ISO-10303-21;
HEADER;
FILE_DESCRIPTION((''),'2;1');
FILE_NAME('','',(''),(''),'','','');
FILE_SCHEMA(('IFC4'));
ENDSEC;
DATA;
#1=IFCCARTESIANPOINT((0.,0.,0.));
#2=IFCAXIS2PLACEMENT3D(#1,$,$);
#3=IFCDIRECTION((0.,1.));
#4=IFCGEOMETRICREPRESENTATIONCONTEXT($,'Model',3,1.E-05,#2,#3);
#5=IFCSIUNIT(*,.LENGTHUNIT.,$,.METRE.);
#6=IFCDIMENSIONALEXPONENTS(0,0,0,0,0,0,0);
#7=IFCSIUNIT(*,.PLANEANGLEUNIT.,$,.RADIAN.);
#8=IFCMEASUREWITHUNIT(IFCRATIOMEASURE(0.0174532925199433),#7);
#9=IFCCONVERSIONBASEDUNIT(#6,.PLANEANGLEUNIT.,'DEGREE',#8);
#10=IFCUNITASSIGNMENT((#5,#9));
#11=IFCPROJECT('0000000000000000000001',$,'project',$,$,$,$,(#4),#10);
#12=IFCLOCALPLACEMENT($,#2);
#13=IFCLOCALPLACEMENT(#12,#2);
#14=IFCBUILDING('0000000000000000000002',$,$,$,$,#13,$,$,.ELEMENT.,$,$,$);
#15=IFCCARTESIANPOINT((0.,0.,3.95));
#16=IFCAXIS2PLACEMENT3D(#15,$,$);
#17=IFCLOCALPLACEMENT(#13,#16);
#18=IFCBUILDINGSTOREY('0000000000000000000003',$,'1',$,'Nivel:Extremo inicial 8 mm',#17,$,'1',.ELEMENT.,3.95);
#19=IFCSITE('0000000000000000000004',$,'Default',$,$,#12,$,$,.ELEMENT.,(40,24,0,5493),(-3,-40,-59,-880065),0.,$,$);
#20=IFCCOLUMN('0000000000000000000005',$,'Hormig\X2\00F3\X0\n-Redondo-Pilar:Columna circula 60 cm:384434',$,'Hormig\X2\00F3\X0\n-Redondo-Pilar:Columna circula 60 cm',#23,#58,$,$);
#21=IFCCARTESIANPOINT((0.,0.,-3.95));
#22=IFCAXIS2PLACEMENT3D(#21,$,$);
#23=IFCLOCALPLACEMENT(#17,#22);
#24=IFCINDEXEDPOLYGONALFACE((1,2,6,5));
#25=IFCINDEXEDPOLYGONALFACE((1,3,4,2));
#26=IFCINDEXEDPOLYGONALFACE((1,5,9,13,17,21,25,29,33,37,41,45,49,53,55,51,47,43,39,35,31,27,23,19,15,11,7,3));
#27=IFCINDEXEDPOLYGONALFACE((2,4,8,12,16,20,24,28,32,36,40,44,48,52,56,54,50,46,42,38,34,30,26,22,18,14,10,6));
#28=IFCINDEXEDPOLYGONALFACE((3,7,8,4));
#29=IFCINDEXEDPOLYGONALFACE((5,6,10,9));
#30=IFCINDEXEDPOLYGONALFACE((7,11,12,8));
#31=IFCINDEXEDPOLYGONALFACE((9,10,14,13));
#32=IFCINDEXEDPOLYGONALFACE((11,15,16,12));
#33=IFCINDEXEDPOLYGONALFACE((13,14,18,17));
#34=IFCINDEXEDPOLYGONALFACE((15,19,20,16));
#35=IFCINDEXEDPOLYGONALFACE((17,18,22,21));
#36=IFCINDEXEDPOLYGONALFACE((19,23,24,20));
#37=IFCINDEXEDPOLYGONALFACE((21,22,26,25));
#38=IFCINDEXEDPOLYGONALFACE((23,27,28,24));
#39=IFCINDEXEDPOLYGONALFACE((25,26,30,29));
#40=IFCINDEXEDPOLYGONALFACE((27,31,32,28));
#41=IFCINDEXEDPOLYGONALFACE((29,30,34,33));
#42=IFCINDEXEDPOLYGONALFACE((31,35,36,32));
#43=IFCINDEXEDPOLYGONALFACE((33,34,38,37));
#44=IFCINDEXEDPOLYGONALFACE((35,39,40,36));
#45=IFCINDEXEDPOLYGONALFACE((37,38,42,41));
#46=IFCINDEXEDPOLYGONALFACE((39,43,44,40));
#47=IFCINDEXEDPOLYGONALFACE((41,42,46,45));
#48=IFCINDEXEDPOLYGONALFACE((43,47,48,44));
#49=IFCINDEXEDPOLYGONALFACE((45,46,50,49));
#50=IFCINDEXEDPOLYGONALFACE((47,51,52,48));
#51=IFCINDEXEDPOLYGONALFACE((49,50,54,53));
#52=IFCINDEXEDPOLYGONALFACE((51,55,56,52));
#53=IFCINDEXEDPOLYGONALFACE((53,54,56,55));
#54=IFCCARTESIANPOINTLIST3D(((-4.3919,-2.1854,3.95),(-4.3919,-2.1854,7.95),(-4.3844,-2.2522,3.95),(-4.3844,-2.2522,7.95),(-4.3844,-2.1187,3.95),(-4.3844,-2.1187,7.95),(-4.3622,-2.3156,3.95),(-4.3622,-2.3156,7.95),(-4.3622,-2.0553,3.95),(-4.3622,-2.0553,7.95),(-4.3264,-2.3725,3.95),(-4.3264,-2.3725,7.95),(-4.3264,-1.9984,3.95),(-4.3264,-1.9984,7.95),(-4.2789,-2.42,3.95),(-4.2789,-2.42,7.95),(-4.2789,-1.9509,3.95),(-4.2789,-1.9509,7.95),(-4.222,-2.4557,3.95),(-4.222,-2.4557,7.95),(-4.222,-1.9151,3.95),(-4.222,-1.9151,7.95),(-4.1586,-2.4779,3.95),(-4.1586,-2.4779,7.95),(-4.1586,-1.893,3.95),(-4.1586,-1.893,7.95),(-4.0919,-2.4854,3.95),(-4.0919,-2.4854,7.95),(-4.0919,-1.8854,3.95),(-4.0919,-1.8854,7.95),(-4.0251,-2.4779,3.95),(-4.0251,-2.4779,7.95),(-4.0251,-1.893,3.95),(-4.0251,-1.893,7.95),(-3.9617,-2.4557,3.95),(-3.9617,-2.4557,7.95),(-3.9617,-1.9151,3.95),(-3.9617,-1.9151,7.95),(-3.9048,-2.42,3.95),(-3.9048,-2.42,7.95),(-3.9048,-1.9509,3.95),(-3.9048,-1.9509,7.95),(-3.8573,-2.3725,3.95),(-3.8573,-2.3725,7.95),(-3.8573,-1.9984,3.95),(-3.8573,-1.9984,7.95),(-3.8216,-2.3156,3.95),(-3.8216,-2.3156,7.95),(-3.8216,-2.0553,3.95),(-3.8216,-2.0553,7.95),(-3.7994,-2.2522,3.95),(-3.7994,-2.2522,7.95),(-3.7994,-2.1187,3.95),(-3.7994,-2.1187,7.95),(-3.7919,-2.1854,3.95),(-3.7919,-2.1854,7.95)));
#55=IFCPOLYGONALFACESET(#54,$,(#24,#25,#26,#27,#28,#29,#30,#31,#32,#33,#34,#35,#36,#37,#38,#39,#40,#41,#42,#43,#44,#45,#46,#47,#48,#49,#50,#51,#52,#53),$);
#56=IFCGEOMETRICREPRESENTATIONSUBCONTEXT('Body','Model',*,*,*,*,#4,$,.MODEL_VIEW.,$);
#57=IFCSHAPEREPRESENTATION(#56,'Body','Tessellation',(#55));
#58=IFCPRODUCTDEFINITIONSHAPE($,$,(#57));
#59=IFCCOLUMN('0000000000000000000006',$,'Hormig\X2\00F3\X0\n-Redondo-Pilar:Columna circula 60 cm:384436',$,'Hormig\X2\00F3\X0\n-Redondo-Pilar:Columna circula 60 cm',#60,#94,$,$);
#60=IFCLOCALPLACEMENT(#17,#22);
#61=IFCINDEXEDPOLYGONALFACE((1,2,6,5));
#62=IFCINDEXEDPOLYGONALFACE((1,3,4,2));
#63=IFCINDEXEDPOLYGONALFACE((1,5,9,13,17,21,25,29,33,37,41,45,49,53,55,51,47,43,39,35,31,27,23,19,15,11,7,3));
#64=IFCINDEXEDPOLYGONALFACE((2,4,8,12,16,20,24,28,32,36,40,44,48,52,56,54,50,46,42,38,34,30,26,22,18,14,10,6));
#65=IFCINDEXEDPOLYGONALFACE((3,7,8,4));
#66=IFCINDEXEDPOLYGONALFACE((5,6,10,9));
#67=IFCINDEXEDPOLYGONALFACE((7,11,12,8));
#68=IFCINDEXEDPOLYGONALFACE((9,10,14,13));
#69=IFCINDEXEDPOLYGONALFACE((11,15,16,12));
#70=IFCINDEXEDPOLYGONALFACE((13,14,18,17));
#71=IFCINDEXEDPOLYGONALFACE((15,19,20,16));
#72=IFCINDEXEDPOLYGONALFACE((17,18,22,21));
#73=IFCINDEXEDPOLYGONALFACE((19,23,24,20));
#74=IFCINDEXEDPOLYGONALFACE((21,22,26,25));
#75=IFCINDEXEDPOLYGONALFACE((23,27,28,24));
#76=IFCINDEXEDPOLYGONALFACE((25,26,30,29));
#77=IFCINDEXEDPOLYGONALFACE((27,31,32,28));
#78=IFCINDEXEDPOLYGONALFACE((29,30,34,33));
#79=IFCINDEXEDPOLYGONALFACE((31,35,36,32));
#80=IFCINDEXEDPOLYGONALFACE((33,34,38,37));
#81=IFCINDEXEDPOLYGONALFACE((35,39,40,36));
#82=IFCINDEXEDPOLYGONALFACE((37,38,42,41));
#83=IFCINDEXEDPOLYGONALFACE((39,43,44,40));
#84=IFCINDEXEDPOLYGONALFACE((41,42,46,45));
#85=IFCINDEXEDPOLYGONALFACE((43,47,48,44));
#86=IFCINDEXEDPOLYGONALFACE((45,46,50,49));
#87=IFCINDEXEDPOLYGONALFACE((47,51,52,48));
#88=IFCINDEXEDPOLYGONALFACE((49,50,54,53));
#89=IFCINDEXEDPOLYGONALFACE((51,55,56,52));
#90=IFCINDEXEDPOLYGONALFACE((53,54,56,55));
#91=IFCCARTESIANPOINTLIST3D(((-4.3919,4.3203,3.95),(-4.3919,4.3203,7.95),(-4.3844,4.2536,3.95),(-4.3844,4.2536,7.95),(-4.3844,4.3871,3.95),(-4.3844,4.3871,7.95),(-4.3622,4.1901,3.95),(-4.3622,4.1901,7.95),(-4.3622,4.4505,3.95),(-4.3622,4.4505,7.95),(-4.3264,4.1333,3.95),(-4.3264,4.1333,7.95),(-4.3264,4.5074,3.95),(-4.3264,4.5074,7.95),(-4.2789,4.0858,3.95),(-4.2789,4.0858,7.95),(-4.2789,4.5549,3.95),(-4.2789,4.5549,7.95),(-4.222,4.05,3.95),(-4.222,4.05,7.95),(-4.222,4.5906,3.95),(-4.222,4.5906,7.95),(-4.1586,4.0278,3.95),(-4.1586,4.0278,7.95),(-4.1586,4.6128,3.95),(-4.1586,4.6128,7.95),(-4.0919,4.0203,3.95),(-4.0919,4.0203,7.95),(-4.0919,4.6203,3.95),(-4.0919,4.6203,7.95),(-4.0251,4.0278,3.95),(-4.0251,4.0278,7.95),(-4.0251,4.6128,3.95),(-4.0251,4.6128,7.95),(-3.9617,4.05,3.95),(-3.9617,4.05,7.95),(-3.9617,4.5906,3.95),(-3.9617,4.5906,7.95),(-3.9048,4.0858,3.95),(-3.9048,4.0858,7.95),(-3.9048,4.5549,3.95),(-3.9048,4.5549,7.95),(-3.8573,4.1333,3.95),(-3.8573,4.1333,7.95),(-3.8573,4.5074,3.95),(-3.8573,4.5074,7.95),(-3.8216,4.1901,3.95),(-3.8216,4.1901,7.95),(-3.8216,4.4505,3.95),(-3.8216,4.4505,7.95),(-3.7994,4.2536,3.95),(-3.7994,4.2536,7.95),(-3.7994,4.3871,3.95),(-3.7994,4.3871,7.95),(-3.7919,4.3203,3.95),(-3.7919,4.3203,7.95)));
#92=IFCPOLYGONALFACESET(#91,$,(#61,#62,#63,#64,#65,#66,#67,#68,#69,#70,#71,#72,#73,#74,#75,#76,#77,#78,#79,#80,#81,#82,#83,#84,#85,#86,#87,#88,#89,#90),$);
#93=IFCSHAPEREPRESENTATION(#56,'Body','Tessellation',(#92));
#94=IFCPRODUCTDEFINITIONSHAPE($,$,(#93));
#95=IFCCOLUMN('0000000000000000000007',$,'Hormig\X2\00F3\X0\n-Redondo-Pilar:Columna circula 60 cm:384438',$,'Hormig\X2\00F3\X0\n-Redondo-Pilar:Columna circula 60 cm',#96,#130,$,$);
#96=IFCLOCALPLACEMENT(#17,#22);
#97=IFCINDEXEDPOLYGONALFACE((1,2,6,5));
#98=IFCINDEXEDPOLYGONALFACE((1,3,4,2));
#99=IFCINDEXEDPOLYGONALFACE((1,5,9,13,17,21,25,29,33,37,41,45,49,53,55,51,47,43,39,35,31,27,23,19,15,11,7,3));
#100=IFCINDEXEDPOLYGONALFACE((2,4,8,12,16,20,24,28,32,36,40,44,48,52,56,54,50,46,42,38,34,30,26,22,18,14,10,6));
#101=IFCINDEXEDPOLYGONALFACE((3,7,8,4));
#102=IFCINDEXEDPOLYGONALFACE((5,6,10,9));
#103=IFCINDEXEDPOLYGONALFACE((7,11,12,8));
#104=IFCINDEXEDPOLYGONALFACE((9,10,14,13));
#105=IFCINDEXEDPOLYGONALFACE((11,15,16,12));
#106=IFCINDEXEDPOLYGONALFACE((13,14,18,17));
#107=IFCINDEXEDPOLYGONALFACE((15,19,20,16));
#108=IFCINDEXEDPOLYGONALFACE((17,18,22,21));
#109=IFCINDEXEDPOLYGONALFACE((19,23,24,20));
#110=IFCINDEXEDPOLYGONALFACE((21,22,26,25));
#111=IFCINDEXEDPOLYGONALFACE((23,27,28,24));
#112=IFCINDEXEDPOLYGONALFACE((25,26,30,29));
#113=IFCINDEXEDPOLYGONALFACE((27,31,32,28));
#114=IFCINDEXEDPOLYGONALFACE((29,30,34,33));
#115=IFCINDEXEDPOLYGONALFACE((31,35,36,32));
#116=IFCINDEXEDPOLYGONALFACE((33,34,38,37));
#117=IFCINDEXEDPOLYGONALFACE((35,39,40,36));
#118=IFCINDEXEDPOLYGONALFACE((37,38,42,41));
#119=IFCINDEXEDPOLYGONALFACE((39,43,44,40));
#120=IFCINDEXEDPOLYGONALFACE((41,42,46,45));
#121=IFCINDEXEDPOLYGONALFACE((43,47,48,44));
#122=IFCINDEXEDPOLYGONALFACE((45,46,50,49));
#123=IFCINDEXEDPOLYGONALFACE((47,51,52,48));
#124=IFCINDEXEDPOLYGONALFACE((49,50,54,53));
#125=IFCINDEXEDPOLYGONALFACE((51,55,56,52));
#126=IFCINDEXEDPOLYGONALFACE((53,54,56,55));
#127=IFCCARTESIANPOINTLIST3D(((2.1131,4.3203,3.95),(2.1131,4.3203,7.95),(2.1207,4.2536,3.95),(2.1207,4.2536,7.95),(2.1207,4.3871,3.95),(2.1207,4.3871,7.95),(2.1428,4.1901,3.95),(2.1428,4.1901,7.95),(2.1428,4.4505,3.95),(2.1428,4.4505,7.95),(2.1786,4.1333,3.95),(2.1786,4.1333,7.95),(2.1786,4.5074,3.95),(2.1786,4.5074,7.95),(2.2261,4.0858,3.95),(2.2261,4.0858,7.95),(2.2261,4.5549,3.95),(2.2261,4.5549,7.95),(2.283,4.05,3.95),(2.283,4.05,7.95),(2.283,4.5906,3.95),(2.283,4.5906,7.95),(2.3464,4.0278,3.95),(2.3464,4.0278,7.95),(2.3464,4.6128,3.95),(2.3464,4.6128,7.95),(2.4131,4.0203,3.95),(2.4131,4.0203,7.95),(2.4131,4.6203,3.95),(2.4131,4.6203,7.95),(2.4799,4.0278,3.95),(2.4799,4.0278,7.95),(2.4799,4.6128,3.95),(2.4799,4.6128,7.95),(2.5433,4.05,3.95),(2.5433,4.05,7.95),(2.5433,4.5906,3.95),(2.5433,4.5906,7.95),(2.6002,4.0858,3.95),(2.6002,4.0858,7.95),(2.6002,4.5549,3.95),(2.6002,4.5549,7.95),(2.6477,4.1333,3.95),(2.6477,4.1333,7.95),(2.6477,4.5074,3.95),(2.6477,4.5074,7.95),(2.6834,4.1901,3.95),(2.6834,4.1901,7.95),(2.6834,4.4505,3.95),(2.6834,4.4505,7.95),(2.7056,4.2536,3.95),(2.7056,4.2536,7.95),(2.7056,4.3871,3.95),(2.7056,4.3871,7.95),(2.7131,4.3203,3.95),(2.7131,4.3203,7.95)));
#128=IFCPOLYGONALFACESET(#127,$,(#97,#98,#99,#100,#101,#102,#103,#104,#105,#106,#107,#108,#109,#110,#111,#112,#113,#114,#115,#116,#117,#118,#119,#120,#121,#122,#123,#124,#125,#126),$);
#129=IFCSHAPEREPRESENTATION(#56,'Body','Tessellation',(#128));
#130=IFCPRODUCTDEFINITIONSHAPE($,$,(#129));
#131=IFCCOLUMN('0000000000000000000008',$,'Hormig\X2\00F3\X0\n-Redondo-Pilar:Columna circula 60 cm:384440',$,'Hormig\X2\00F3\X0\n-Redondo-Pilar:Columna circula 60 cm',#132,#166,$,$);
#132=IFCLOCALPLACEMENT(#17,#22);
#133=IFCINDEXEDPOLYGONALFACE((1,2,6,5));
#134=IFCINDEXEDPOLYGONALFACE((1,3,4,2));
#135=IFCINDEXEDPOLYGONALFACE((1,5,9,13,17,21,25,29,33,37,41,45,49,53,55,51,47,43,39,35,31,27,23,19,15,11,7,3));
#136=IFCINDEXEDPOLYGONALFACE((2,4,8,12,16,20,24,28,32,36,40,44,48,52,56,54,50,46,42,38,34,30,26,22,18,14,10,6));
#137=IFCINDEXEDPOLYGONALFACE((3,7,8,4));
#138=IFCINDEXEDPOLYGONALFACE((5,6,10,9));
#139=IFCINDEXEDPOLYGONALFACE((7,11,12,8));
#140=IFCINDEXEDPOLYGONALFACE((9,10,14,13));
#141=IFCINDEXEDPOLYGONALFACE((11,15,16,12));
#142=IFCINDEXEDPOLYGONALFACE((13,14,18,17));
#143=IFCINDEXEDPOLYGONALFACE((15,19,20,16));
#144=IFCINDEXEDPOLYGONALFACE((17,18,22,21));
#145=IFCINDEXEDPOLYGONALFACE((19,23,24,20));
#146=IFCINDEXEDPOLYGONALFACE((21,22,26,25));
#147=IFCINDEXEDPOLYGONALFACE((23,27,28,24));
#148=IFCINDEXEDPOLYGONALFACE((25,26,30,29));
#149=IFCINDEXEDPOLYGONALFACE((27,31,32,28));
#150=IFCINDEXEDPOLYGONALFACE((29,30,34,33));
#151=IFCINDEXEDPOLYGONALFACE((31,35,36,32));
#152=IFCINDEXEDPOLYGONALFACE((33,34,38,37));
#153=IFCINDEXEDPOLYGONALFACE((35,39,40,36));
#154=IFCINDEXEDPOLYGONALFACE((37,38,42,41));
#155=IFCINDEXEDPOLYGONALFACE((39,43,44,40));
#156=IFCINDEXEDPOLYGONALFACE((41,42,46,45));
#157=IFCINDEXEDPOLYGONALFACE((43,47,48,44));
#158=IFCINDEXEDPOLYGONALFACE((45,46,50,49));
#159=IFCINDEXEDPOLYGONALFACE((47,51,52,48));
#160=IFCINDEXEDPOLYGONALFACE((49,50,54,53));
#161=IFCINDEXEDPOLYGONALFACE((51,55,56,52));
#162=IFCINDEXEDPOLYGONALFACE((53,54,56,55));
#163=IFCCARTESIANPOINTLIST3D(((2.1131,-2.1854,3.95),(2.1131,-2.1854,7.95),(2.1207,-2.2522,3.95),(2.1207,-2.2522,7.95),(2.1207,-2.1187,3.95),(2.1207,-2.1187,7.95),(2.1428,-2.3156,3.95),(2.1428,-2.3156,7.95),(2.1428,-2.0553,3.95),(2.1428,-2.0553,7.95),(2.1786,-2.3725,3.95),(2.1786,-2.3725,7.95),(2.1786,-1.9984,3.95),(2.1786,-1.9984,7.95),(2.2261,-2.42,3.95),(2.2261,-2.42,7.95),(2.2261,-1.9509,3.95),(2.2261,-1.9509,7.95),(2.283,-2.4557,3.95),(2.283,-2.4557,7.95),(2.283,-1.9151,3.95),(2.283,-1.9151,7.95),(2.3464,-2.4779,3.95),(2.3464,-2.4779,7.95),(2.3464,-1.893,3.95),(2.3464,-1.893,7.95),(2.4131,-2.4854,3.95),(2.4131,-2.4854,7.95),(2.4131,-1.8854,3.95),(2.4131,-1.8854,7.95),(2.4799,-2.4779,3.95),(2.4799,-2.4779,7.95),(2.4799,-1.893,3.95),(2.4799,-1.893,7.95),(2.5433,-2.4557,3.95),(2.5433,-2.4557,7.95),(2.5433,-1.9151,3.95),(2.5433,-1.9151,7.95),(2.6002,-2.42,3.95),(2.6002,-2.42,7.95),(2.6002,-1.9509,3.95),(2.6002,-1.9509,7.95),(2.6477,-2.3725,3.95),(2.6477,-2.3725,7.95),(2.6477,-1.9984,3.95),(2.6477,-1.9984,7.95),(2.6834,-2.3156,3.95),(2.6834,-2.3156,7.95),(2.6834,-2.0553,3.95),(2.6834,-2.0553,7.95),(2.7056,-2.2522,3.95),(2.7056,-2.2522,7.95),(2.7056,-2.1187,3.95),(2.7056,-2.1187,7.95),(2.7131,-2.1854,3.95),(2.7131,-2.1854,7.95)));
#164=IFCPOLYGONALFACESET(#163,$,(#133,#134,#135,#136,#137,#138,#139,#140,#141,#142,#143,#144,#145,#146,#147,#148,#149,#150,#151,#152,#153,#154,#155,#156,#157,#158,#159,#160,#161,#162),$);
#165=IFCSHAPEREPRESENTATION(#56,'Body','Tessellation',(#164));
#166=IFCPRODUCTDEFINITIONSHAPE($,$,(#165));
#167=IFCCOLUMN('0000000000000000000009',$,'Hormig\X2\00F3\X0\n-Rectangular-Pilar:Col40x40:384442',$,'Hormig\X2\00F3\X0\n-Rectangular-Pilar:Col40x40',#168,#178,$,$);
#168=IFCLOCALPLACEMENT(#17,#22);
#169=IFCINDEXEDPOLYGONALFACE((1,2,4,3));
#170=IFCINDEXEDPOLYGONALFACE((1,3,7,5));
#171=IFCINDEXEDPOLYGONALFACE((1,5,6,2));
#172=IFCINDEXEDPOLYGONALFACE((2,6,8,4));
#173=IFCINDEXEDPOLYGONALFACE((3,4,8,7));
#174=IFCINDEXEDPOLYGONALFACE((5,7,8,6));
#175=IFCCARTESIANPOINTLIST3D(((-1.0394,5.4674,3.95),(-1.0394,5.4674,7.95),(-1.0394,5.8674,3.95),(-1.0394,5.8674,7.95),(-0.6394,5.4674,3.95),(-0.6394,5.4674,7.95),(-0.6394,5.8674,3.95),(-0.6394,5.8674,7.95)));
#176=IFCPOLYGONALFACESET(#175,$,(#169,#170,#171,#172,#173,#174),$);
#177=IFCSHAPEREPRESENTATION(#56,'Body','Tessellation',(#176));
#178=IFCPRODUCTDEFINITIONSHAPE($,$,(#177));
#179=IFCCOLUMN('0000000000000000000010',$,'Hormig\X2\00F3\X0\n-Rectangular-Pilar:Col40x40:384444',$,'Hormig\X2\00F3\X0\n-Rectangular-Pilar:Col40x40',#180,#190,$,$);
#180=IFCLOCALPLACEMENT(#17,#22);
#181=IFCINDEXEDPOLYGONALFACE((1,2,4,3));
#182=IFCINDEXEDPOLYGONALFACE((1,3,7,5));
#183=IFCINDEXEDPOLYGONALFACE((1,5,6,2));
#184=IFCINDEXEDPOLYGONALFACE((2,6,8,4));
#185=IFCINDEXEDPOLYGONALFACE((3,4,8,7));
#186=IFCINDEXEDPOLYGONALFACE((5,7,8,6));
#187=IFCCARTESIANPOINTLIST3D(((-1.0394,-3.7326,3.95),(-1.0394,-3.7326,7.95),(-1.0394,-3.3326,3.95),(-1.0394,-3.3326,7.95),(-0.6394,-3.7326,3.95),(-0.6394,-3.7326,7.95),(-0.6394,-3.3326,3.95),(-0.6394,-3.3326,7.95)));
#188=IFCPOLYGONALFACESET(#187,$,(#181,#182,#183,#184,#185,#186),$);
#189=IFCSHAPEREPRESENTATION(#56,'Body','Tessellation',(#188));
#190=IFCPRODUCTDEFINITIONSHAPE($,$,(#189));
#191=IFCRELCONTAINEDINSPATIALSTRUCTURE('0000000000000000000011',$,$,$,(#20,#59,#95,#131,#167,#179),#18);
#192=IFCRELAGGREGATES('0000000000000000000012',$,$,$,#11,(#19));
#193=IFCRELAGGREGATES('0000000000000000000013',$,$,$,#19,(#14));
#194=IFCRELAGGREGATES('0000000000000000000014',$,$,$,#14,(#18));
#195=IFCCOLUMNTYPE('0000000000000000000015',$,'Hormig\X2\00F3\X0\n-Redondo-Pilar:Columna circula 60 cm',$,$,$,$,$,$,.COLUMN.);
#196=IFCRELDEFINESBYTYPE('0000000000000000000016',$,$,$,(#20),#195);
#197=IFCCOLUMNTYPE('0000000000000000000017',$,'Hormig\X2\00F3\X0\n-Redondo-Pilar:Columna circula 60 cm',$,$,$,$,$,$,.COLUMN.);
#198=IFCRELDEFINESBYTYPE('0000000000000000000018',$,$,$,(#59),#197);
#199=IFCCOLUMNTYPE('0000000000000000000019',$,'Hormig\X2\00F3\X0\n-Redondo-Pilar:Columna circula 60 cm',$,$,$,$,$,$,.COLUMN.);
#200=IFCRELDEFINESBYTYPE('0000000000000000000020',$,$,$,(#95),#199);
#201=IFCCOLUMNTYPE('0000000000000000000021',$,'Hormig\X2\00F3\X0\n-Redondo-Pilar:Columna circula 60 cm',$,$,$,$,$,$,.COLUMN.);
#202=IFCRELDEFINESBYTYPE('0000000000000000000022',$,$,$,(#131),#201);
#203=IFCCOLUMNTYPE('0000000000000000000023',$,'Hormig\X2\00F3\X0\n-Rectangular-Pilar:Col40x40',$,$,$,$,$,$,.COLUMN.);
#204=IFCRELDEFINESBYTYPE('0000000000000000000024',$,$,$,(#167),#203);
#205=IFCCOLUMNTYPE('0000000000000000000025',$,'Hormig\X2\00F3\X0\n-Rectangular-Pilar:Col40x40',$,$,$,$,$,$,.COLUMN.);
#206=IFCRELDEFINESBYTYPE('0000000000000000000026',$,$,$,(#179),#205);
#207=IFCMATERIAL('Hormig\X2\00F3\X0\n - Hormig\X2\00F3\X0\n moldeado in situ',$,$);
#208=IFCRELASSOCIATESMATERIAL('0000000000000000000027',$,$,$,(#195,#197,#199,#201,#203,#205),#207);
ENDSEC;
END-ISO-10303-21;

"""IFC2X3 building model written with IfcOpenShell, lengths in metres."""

from ifc_helpers import new_model, entity, si_unit, converted_unit, direction, frame, frame_2d, origin, origin_2d_with_axis, place, context, subcontext, project, spatial, rectangle, circle, extrude, source, transform, mapped, material, type_object, type_shapes, element, save


model = new_model("IFC2X3")

# Units and contexts
model_context = context("Model", 3, precision=1e-05, world=origin(), true_north=direction((0.0, 1.0)))
body_context = subcontext(model_context, "Body", "Model", "MODEL_VIEW")
ifc_project = project(units=[si_unit("LENGTHUNIT", "METRE"), converted_unit("PLANEANGLEUNIT", "DEGREE", entity("IfcRatioMeasure", 0.0174532925199433), si_unit("PLANEANGLEUNIT", "RADIAN"), dimensions=[0, 0, 0, 0, 0, 0, 0])], contexts=[model_context])

# Site, building, storey
site_placement = place(None, origin())
site = spatial("IfcSite", under=ifc_project, at=site_placement, Name="Default", CompositionType="ELEMENT", RefLatitude=(40, 24, 0, 5493), RefLongitude=(-3, -40, -59, -880065), RefElevation=0.0)
building_placement = place(site_placement, origin())
building = spatial("IfcBuilding", under=site, at=building_placement, CompositionType="ELEMENT")
storey_placement = place(building_placement, frame((0.0, 0.0, 3.95)))
storey = spatial("IfcBuildingStorey", under=building, at=storey_placement, Name="1", ObjectType="Nivel:Extremo inicial 8 mm", LongName="1", CompositionType="ELEMENT", Elevation=3.95)

# Columns
ifc_material_1 = material(Name="Hormigón - Hormigón moldeado in situ")
column_type_1 = type_object("IfcColumnType", Name="Hormigón-Redondo-Pilar:Columna circula 60 cm", PredefinedType="COLUMN", material=ifc_material_1)
shared_shape_1 = source(origin(), body_context, "Body", "SweptSolid", [
    extrude(circle(Radius=0.3, at=frame_2d((0.0, 0.0), x_axis=(1.0, 0.0))), frame((-4.0919, -2.1854, 3.95)), (0.0, 0.0, 1.0), 4.0),
])
type_shapes(column_type_1, [shared_shape_1])
column_1_placement = place(storey_placement, frame((0.0, 0.0, -3.95)))
element("IfcColumn", 1, at=column_1_placement, inside=storey, type_object=column_type_1, Name="Hormigón-Redondo-Pilar:Columna circula 60 cm:384434", ObjectType="Hormigón-Redondo-Pilar:Columna circula 60 cm", context=body_context, shape_type="MappedRepresentation", body=[
    mapped(shared_shape_1, transform((0.0, 0.0, 0.0), scale=1.0)),
])
column_type_2 = type_object("IfcColumnType", Name="Hormigón-Redondo-Pilar:Columna circula 60 cm", PredefinedType="COLUMN", material=ifc_material_1)
shared_shape_2 = source(origin(), body_context, "Body", "SweptSolid", [
    extrude(circle(Radius=0.3, at=frame_2d((0.0, 0.0), x_axis=(1.0, 0.0))), frame((-4.0919, 4.3203, 3.95)), (0.0, 0.0, 1.0), 4.0),
])
type_shapes(column_type_2, [shared_shape_2])
column_2_placement = place(storey_placement, frame((0.0, 0.0, -3.95)))
element("IfcColumn", 2, at=column_2_placement, inside=storey, type_object=column_type_2, Name="Hormigón-Redondo-Pilar:Columna circula 60 cm:384436", ObjectType="Hormigón-Redondo-Pilar:Columna circula 60 cm", context=body_context, shape_type="MappedRepresentation", body=[
    mapped(shared_shape_2, transform((0.0, 0.0, 0.0), scale=1.0)),
])
column_type_3 = type_object("IfcColumnType", Name="Hormigón-Redondo-Pilar:Columna circula 60 cm", PredefinedType="COLUMN", material=ifc_material_1)
shared_shape_3 = source(origin(), body_context, "Body", "SweptSolid", [
    extrude(circle(Radius=0.3, at=frame_2d((0.0, 0.0), x_axis=(1.0, 0.0))), frame((2.4131, 4.3203, 3.95)), (0.0, 0.0, 1.0), 4.0),
])
type_shapes(column_type_3, [shared_shape_3])
column_3_placement = place(storey_placement, frame((0.0, 0.0, -3.95)))
element("IfcColumn", 3, at=column_3_placement, inside=storey, type_object=column_type_3, Name="Hormigón-Redondo-Pilar:Columna circula 60 cm:384438", ObjectType="Hormigón-Redondo-Pilar:Columna circula 60 cm", context=body_context, shape_type="MappedRepresentation", body=[
    mapped(shared_shape_3, transform((0.0, 0.0, 0.0), scale=1.0)),
])
column_type_4 = type_object("IfcColumnType", Name="Hormigón-Redondo-Pilar:Columna circula 60 cm", PredefinedType="COLUMN", material=ifc_material_1)
shared_shape_4 = source(origin(), body_context, "Body", "SweptSolid", [
    extrude(circle(Radius=0.3, at=frame_2d((0.0, 0.0), x_axis=(1.0, 0.0))), frame((2.4131, -2.1854, 3.95)), (0.0, 0.0, 1.0), 4.0),
])
type_shapes(column_type_4, [shared_shape_4])
column_4_placement = place(storey_placement, frame((0.0, 0.0, -3.95)))
element("IfcColumn", 4, at=column_4_placement, inside=storey, type_object=column_type_4, Name="Hormigón-Redondo-Pilar:Columna circula 60 cm:384440", ObjectType="Hormigón-Redondo-Pilar:Columna circula 60 cm", context=body_context, shape_type="MappedRepresentation", body=[
    mapped(shared_shape_4, transform((0.0, 0.0, 0.0), scale=1.0)),
])
column_type_5 = type_object("IfcColumnType", Name="Hormigón-Rectangular-Pilar:Col40x40", PredefinedType="COLUMN", material=ifc_material_1)
shared_shape_5 = source(origin(), body_context, "Body", "SweptSolid", [
    extrude(rectangle(XDim=0.4, YDim=0.4, at=origin_2d_with_axis()), frame((-0.8394, 5.6674, 3.95), z_axis=(0.0, 0.0, 1.0), x_axis=(0.0, -1.0, 0.0)), (0.0, 0.0, 1.0), 4.0),
])
type_shapes(column_type_5, [shared_shape_5])
column_5_placement = place(storey_placement, frame((0.0, 0.0, -3.95)))
element("IfcColumn", 5, at=column_5_placement, inside=storey, type_object=column_type_5, Name="Hormigón-Rectangular-Pilar:Col40x40:384442", ObjectType="Hormigón-Rectangular-Pilar:Col40x40", context=body_context, shape_type="MappedRepresentation", body=[
    mapped(shared_shape_5, transform((0.0, 0.0, 0.0), scale=1.0)),
])
column_type_6 = type_object("IfcColumnType", Name="Hormigón-Rectangular-Pilar:Col40x40", PredefinedType="COLUMN", material=ifc_material_1)
shared_shape_6 = source(origin(), body_context, "Body", "SweptSolid", [
    extrude(rectangle(XDim=0.4, YDim=0.4, at=origin_2d_with_axis()), frame((-0.8394, -3.5326, 3.95), z_axis=(0.0, 0.0, 1.0), x_axis=(0.0, -1.0, 0.0)), (0.0, 0.0, 1.0), 4.0),
])
type_shapes(column_type_6, [shared_shape_6])
column_6_placement = place(storey_placement, frame((0.0, 0.0, -3.95)))
element("IfcColumn", 6, at=column_6_placement, inside=storey, type_object=column_type_6, Name="Hormigón-Rectangular-Pilar:Col40x40:384444", ObjectType="Hormigón-Rectangular-Pilar:Col40x40", context=body_context, shape_type="MappedRepresentation", body=[
    mapped(shared_shape_6, transform((0.0, 0.0, 0.0), scale=1.0)),
])

save(model, "model.ifc")
